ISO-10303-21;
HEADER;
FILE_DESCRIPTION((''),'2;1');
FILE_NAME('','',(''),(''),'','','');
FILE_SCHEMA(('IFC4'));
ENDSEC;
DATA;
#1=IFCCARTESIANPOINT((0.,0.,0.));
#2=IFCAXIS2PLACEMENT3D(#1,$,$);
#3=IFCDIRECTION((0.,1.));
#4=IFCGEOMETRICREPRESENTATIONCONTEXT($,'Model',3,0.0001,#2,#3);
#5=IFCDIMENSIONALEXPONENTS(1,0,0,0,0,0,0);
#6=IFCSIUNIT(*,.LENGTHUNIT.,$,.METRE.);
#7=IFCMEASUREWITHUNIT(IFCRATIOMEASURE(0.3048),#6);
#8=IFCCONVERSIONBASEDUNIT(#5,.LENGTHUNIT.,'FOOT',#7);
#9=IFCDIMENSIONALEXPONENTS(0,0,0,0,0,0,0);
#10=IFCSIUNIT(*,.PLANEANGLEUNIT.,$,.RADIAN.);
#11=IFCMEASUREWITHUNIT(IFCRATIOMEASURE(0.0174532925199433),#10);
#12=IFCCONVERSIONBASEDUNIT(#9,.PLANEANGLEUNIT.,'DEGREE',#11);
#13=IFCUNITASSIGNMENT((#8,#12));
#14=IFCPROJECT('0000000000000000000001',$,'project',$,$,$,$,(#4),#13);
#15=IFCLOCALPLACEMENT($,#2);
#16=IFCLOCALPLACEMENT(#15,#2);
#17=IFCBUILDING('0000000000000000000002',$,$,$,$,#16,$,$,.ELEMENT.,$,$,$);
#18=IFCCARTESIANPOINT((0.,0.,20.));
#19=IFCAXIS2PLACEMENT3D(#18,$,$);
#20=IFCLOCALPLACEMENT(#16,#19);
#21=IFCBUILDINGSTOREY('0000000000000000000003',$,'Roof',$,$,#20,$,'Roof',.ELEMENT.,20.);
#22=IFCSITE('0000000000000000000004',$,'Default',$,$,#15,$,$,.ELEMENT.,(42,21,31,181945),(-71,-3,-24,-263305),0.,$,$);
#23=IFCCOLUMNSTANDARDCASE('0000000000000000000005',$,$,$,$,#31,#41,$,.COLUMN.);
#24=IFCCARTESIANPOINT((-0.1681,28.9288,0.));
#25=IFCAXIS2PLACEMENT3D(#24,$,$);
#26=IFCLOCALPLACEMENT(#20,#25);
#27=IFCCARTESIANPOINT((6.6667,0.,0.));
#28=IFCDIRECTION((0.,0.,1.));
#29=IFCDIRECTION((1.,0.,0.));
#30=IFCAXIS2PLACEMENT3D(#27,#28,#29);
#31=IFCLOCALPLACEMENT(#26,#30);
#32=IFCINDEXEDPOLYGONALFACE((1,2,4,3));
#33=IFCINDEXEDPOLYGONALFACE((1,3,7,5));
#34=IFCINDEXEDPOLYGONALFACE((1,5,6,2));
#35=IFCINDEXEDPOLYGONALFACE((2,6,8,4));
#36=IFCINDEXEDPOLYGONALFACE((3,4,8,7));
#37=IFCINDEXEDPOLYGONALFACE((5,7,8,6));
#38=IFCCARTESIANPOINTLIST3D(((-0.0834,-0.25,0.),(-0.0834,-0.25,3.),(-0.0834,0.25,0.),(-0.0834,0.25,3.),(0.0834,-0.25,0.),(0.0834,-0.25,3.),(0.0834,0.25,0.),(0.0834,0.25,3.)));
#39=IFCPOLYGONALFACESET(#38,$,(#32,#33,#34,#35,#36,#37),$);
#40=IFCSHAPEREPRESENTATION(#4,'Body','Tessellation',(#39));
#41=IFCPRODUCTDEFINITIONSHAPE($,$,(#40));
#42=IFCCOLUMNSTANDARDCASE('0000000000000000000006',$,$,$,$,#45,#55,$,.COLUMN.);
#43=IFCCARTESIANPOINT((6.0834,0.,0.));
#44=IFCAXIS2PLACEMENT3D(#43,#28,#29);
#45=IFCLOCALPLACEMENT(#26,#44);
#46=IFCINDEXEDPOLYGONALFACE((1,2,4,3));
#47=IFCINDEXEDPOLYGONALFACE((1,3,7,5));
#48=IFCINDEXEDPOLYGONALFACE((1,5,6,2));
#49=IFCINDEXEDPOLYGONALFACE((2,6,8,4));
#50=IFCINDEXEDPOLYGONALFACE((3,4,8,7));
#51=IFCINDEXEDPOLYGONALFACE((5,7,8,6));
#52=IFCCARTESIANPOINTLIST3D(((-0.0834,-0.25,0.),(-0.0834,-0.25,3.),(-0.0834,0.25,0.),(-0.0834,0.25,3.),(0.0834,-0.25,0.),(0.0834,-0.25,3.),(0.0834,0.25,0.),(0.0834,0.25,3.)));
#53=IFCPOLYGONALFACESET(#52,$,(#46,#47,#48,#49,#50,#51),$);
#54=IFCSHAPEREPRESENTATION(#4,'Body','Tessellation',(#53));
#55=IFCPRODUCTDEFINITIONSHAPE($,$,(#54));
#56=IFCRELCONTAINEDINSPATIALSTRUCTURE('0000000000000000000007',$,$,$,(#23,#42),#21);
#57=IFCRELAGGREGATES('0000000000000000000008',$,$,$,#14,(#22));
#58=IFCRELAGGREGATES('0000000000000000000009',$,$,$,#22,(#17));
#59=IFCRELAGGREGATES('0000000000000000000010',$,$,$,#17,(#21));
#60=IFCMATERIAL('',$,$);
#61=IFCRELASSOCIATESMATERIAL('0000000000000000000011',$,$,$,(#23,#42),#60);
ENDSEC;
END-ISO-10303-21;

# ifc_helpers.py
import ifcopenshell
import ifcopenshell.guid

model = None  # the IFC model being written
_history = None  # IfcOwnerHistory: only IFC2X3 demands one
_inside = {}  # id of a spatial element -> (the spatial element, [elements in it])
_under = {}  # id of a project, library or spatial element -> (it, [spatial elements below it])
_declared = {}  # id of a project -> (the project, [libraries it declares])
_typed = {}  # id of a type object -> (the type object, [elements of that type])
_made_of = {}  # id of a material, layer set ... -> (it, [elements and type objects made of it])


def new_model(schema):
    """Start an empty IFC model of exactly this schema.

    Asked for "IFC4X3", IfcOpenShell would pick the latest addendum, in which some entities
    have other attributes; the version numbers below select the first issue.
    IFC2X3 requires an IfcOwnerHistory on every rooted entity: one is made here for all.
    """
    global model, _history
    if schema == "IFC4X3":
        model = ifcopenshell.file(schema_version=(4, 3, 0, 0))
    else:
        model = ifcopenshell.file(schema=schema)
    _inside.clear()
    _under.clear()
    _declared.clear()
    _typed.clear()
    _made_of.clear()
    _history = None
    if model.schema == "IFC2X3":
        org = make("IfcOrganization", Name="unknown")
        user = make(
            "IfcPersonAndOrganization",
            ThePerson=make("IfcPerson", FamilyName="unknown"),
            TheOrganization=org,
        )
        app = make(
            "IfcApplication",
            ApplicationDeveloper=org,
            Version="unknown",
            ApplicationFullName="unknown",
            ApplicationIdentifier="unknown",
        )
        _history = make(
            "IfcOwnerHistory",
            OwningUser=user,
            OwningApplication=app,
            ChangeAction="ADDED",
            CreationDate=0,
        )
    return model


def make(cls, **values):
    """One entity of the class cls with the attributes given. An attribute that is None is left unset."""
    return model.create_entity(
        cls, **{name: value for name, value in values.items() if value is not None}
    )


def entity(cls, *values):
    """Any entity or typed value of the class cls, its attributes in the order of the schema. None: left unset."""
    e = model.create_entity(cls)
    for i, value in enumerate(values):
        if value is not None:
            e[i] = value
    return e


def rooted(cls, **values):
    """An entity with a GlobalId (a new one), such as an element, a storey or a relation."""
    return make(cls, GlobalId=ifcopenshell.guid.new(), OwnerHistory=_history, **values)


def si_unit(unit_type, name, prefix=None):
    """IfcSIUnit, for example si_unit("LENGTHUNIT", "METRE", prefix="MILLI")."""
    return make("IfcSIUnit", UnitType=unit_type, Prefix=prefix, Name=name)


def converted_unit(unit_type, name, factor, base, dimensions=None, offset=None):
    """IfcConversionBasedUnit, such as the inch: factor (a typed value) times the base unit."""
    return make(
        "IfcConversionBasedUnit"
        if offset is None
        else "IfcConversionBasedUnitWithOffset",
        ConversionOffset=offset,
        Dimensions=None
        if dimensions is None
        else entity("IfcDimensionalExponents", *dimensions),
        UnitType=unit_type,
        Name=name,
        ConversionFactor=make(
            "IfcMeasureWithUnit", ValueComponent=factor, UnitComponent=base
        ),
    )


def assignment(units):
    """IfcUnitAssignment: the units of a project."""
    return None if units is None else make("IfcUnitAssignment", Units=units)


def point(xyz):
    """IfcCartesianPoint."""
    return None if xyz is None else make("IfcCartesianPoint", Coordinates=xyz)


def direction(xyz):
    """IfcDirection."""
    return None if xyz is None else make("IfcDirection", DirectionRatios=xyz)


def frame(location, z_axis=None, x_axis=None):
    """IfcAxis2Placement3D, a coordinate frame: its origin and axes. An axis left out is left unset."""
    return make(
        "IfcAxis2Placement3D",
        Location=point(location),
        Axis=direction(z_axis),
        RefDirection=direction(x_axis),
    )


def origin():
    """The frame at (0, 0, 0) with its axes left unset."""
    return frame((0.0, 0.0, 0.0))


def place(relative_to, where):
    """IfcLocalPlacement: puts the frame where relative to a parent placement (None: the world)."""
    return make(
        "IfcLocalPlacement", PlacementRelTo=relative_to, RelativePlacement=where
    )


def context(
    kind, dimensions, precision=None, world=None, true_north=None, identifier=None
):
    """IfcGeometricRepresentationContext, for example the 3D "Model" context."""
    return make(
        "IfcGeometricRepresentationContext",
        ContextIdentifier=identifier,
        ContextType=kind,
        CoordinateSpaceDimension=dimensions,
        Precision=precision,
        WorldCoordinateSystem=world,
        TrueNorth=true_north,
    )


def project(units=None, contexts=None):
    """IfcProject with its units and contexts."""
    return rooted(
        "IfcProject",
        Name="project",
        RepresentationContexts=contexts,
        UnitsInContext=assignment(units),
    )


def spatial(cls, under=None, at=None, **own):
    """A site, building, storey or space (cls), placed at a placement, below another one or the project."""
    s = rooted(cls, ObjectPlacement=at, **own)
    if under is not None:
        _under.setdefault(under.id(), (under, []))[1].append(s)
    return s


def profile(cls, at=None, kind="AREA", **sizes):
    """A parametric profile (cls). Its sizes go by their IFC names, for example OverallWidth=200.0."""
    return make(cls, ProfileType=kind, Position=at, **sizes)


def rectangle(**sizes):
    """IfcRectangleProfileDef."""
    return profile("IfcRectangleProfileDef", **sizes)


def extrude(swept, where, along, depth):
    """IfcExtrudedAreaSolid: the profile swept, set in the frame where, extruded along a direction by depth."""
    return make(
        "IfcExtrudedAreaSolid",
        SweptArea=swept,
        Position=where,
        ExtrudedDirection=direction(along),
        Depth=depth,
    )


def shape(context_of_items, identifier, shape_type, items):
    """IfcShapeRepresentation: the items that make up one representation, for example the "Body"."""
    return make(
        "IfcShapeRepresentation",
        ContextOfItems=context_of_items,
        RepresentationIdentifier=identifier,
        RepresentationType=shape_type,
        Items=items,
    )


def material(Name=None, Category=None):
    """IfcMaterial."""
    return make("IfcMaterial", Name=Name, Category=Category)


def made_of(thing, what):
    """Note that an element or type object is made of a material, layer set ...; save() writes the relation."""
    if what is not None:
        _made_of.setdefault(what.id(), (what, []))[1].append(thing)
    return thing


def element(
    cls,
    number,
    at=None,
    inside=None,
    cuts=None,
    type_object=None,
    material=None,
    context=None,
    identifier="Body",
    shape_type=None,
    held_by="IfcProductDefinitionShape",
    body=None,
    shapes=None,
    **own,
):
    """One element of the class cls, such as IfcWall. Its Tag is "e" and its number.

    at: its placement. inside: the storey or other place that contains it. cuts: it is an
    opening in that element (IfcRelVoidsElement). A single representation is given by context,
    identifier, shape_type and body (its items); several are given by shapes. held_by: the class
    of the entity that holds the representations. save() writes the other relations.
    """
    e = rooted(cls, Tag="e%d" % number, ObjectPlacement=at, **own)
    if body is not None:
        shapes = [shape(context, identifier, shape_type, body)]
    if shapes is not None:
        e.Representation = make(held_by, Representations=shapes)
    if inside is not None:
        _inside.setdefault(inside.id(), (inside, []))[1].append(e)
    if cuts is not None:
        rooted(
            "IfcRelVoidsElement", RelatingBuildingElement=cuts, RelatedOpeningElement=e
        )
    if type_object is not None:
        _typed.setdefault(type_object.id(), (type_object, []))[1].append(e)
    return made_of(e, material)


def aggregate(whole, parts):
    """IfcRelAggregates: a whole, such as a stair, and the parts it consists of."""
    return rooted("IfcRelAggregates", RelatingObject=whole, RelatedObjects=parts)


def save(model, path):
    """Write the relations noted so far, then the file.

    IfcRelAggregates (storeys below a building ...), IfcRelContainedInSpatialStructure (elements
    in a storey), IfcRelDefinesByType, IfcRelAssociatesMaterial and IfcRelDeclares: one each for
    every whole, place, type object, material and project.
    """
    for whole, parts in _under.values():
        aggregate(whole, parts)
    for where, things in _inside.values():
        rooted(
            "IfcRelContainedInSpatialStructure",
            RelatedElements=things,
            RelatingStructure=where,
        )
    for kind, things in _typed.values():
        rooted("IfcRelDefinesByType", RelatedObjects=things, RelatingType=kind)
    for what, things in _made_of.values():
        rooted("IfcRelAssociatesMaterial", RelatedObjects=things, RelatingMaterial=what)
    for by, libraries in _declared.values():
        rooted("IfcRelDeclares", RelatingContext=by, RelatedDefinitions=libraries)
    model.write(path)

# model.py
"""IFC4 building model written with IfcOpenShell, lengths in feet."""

from ifc_helpers import new_model, entity, si_unit, converted_unit, direction, frame, origin, place, context, project, spatial, rectangle, extrude, material, element, save


model = new_model("IFC4")

# Units and contexts
model_context = context("Model", 3, precision=0.0001, world=origin(), true_north=direction((0.0, 1.0)))
ifc_project = project(units=[converted_unit("LENGTHUNIT", "FOOT", entity("IfcRatioMeasure", 0.3048), si_unit("LENGTHUNIT", "METRE"), dimensions=[1, 0, 0, 0, 0, 0, 0]), converted_unit("PLANEANGLEUNIT", "DEGREE", entity("IfcRatioMeasure", 0.0174532925199433), si_unit("PLANEANGLEUNIT", "RADIAN"), dimensions=[0, 0, 0, 0, 0, 0, 0])], contexts=[model_context])

# Site, building, storey
site_placement = place(None, origin())
site = spatial("IfcSite", under=ifc_project, at=site_placement, Name="Default", CompositionType="ELEMENT", RefLatitude=(42, 21, 31, 181945), RefLongitude=(-71, -3, -24, -263305), RefElevation=0.0)
building_placement = place(site_placement, origin())
building = spatial("IfcBuilding", under=site, at=building_placement, CompositionType="ELEMENT")
storey_placement = place(building_placement, frame((0.0, 0.0, 20.0)))
storey = spatial("IfcBuildingStorey", under=building, at=storey_placement, Name="Roof", LongName="Roof", CompositionType="ELEMENT", Elevation=20.0)

# Columns
ifc_material = material(Name="")
placement = place(storey_placement, frame((-0.1681, 28.9288, 0.0)))
for number, where, z_axis, x_axis in (
    (1, (6.6667, 0.0, 0.0), (0.0, 0.0, 1.0), (1.0, 0.0, 0.0)),
    (2, (6.0834, 0.0, 0.0), (0.0, 0.0, 1.0), (1.0, 0.0, 0.0)),
):
    element("IfcColumnStandardCase", number, at=place(placement, frame(where, z_axis=z_axis, x_axis=x_axis)), inside=storey, material=ifc_material, PredefinedType="COLUMN", context=model_context, shape_type="SweptSolid", body=[
        extrude(rectangle(XDim=0.1667, YDim=0.5), origin(), (0.0, 0.0, 1.0), 3.0),
    ])

save(model, "model.ifc")
